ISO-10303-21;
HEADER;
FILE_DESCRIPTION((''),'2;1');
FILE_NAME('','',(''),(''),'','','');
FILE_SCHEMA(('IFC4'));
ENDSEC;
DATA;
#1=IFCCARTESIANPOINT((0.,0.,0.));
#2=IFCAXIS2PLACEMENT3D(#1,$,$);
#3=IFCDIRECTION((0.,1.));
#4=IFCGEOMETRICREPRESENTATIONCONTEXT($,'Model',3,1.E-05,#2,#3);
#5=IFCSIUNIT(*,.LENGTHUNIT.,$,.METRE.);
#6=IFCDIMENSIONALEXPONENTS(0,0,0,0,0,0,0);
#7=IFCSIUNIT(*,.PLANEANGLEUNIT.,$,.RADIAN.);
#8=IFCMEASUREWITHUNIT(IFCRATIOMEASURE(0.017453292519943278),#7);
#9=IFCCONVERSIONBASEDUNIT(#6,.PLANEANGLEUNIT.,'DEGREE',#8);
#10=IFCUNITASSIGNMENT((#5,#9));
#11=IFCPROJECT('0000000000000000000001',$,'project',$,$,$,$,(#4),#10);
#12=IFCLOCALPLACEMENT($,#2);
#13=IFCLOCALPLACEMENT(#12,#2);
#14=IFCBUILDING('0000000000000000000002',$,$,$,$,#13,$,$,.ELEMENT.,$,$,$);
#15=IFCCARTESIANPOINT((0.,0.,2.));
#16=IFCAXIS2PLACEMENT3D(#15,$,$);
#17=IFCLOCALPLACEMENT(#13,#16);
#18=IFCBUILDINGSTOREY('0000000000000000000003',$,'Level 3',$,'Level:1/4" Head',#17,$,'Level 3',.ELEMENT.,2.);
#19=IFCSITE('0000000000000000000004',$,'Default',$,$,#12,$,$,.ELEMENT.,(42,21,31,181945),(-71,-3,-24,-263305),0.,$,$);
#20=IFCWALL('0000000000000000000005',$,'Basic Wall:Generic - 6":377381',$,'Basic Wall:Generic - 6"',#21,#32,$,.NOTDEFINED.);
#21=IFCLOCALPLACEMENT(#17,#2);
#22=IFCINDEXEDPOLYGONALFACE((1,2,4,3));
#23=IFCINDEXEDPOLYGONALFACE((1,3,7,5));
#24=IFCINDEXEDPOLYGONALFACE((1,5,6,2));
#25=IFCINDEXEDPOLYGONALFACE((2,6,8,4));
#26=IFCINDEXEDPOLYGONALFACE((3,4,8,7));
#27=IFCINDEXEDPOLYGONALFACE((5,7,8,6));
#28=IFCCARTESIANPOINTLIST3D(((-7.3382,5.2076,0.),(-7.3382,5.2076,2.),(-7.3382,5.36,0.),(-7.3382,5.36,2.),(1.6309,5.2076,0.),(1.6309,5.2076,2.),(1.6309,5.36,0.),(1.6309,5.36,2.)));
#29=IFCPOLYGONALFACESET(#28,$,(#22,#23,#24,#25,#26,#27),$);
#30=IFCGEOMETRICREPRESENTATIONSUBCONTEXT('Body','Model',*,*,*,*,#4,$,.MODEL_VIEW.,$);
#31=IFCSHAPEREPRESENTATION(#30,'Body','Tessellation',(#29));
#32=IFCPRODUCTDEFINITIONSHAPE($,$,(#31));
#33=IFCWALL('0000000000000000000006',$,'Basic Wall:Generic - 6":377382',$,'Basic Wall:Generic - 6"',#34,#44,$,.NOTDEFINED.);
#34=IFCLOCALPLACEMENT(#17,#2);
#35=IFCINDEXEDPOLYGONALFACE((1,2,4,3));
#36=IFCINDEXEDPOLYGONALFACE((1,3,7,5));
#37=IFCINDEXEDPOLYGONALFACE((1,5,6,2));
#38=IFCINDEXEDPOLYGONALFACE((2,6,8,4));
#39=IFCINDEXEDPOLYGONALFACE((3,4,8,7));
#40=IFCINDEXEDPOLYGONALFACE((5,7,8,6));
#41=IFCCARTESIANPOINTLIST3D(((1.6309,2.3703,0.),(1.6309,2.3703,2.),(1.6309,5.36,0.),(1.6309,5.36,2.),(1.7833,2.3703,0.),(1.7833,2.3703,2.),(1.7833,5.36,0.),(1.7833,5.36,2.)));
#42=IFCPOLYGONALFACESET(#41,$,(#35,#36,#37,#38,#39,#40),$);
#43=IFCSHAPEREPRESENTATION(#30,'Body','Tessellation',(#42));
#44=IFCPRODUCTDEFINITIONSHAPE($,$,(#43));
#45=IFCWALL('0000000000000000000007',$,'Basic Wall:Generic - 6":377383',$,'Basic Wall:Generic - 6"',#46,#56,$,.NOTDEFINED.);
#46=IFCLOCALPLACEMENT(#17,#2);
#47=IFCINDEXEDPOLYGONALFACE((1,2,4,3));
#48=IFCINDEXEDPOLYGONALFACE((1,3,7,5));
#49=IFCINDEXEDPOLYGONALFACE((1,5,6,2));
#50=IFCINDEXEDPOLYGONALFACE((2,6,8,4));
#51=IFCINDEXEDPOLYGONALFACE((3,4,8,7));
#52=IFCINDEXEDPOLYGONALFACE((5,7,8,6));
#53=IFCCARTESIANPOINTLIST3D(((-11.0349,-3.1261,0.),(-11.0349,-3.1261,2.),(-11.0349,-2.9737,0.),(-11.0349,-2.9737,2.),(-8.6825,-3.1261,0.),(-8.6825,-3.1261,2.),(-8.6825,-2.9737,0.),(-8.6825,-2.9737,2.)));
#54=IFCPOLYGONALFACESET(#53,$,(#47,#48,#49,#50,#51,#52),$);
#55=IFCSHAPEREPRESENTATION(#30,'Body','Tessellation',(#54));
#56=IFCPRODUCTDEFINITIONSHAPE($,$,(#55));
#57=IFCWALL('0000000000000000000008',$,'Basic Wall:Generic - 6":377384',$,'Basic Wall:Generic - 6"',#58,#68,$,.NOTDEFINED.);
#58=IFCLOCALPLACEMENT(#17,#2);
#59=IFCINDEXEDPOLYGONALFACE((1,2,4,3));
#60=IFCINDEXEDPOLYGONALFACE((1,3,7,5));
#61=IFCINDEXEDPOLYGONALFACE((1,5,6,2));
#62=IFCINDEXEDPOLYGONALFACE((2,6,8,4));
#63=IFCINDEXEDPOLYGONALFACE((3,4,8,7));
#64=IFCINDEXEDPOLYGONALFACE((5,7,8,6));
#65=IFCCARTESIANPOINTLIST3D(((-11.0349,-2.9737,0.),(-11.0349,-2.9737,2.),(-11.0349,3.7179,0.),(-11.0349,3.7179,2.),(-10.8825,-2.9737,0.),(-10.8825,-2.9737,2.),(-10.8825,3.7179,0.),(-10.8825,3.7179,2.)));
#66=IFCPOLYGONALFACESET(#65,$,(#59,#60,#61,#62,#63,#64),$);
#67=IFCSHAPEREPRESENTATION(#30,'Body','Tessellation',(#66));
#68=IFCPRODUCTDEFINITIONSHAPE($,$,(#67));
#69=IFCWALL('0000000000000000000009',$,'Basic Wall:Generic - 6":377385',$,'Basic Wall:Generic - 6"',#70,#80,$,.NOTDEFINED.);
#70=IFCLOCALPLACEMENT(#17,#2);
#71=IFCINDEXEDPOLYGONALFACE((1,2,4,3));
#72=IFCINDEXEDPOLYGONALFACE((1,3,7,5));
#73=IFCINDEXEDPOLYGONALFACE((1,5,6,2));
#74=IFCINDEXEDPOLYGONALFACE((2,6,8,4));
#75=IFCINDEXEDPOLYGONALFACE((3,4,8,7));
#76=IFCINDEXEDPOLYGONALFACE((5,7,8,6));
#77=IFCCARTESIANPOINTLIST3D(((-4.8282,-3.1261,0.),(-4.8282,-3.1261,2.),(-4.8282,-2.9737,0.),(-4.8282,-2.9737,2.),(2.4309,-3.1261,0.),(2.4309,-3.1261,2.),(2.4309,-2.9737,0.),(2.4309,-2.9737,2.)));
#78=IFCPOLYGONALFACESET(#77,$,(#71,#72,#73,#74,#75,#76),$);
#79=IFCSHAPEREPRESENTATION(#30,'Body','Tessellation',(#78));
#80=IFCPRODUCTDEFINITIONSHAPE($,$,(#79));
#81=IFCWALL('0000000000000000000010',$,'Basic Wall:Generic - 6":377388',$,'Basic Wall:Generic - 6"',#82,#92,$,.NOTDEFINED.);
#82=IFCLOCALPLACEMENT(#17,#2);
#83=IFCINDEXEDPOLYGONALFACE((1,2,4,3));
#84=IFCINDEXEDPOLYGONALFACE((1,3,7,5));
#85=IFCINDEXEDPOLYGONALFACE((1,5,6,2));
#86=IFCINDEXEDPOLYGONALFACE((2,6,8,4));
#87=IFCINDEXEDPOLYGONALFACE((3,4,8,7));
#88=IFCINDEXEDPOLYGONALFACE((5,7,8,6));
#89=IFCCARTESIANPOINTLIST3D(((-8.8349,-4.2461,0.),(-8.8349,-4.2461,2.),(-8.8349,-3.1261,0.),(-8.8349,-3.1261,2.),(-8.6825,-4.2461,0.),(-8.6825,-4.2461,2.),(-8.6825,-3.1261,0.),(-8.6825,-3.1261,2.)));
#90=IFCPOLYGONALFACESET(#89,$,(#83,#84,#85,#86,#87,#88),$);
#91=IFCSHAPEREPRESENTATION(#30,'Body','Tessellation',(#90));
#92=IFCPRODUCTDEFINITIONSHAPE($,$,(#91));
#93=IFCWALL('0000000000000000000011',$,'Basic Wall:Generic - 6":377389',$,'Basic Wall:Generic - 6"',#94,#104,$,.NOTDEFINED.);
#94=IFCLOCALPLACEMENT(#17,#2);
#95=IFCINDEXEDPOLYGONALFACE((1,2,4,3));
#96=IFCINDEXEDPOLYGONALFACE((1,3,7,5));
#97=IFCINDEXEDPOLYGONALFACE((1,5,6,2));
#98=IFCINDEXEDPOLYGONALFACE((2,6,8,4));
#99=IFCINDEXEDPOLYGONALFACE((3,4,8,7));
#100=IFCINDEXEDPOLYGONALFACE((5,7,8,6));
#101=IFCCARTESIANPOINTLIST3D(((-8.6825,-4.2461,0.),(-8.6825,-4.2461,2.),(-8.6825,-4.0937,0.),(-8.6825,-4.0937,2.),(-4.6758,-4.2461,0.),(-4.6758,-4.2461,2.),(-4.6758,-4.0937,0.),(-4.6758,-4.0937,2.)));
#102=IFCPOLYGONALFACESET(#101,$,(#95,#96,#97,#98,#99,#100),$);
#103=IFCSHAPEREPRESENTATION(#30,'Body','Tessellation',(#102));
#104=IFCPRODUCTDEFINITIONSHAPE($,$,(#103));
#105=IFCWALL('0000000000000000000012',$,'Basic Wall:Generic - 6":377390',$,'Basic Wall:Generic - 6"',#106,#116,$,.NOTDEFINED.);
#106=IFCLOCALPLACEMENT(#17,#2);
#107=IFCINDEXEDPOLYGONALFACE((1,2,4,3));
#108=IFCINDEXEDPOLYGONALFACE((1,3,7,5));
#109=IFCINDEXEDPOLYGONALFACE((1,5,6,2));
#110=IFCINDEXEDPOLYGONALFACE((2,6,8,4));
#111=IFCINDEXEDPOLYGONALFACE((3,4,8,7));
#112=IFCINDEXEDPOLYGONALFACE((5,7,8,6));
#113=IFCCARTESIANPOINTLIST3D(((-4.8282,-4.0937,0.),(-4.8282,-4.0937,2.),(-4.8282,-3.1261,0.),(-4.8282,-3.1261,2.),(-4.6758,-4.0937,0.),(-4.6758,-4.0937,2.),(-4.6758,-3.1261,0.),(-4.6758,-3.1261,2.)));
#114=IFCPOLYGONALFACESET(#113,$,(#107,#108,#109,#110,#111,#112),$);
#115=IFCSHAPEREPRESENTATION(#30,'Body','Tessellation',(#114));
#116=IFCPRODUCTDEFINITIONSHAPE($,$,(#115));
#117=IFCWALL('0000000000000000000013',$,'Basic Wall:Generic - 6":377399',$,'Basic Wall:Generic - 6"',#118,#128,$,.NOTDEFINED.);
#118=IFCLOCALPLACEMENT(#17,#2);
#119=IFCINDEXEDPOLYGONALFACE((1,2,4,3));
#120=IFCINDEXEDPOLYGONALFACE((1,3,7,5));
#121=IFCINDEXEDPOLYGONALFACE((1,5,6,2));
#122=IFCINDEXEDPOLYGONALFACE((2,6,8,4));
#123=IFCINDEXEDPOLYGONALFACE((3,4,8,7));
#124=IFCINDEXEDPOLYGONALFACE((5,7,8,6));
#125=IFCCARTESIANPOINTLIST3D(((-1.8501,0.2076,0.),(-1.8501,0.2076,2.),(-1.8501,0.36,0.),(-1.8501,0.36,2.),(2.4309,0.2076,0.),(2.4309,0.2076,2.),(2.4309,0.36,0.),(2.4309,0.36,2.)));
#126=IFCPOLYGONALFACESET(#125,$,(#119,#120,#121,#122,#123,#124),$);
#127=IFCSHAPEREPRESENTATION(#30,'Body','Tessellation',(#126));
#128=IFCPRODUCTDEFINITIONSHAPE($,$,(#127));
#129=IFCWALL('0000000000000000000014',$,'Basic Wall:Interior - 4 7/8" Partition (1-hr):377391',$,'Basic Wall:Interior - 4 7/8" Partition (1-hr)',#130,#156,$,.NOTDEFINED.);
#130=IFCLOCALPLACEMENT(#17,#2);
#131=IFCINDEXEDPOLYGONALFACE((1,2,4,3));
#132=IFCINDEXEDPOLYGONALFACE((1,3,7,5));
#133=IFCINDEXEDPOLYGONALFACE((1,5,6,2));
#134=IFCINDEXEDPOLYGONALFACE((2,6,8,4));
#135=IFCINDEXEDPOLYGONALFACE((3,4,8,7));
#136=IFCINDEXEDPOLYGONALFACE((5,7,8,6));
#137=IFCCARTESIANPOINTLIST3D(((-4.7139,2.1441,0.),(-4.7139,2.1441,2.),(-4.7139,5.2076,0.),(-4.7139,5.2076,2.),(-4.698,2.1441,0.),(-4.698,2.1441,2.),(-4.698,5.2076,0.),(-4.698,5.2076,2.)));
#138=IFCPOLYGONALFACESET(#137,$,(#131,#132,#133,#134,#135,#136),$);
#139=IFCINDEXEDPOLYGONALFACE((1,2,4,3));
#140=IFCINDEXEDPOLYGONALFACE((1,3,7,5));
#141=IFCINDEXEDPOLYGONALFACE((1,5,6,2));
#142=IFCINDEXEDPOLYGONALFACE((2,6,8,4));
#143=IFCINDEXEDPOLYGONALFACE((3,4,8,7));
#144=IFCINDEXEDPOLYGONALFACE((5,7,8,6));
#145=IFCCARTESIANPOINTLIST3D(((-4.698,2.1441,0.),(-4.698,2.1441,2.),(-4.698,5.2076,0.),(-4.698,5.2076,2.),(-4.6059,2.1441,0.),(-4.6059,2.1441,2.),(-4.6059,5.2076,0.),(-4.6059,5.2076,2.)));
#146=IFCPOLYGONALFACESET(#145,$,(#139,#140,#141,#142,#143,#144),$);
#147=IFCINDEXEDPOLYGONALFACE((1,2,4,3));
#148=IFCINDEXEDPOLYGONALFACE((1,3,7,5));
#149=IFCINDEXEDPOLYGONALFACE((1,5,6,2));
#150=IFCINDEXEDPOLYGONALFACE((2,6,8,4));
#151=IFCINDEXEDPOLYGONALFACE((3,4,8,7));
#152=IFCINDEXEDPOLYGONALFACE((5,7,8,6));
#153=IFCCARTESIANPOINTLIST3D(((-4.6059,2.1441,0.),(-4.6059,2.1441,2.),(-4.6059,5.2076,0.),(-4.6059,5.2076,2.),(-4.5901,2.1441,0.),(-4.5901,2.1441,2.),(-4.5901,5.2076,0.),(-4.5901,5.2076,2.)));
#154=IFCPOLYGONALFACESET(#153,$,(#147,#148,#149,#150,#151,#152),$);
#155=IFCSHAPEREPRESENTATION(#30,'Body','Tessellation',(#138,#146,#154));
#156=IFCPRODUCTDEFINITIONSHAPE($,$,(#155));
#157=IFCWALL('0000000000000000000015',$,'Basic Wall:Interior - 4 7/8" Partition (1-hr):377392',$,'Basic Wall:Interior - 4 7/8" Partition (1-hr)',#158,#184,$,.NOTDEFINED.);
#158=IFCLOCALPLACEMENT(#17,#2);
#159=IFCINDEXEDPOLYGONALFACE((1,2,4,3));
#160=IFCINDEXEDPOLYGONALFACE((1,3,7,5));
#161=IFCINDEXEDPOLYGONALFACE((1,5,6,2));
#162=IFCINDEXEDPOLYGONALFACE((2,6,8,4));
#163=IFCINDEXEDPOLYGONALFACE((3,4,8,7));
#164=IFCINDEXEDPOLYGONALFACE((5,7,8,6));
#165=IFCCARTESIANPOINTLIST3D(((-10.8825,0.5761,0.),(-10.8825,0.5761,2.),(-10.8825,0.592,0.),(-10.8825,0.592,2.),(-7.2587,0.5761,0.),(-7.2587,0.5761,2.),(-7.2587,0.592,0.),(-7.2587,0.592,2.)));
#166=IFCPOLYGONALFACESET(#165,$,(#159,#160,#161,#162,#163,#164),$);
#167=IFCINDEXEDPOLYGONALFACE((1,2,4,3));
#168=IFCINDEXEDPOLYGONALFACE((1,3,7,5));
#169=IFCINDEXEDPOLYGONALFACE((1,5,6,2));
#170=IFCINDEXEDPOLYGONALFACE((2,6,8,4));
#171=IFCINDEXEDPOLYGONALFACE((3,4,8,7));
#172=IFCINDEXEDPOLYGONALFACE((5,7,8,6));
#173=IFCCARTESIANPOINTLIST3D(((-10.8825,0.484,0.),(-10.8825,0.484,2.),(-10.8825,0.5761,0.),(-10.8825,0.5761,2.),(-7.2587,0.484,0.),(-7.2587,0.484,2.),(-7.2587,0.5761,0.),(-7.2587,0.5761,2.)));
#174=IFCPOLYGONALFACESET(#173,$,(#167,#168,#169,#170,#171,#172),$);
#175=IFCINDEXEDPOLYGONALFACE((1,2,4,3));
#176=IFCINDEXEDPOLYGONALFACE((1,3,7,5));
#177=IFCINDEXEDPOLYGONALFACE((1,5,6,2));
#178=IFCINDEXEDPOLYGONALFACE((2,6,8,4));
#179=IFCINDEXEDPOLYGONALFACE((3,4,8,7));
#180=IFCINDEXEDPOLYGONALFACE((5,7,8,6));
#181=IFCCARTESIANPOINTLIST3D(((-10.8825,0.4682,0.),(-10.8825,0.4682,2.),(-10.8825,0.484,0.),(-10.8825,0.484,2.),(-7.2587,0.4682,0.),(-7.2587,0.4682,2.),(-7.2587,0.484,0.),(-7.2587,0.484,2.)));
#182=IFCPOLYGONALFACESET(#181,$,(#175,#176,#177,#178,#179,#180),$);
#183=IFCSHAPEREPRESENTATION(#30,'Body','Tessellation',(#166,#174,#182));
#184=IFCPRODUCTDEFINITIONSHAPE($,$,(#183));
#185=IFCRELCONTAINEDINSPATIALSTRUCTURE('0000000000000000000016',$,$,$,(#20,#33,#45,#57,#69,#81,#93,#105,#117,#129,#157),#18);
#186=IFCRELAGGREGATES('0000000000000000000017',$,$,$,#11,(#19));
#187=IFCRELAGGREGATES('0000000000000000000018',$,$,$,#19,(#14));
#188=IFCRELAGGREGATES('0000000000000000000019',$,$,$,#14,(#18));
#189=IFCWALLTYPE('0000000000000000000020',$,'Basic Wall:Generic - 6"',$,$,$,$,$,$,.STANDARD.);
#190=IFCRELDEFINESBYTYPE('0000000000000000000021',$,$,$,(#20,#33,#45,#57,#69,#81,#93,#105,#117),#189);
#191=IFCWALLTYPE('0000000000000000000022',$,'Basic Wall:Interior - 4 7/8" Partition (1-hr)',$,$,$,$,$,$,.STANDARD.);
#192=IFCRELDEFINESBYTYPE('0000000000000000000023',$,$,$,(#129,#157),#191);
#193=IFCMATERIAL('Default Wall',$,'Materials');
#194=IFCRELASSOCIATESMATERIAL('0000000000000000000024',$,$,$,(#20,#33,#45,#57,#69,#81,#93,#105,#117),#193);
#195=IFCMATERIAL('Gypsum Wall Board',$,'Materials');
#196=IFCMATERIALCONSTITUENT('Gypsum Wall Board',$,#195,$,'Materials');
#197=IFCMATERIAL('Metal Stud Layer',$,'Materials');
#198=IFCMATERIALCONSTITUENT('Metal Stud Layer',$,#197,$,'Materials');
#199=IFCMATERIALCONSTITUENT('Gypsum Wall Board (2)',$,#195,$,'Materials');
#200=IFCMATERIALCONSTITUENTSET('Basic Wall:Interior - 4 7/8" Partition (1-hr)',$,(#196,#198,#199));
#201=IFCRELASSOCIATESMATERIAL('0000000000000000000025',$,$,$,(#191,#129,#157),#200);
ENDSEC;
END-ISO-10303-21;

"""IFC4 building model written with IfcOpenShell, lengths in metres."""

from ifc_helpers import new_model, entity, si_unit, converted_unit, direction, frame, origin, place, context, subcontext, project, spatial, indexed_curve, outline, extrude, material, constituent, constituent_set, type_object, element, save


model = new_model("IFC4")

# Units and contexts
model_context = context("Model", 3, precision=1e-05, world=origin(), true_north=direction((0.0, 1.0)))
body_context = subcontext(model_context, "Body", "Model", "MODEL_VIEW")
ifc_project = project(units=[si_unit("LENGTHUNIT", "METRE"), converted_unit("PLANEANGLEUNIT", "DEGREE", entity("IfcRatioMeasure", 0.017453292519943278), si_unit("PLANEANGLEUNIT", "RADIAN"), dimensions=[0, 0, 0, 0, 0, 0, 0])], contexts=[model_context])

# Site, building, storey
site_placement = place(None, origin())
site = spatial("IfcSite", under=ifc_project, at=site_placement, Name="Default", CompositionType="ELEMENT", RefLatitude=(42, 21, 31, 181945), RefLongitude=(-71, -3, -24, -263305), RefElevation=0.0)
building_placement = place(site_placement, origin())
building = spatial("IfcBuilding", under=site, at=building_placement, CompositionType="ELEMENT")
storey_placement = place(building_placement, frame((0.0, 0.0, 2.0)))
storey = spatial("IfcBuildingStorey", under=building, at=storey_placement, Name="Level 3", ObjectType="Level:1/4\" Head", LongName="Level 3", CompositionType="ELEMENT", Elevation=2.0)

# Walls
ifc_material_1 = material(Name="Default Wall", Category="Materials")
wall_type_1 = type_object("IfcWallType", Name="Basic Wall:Generic - 6\"", PredefinedType="STANDARD")
wall_1_placement = place(storey_placement, frame((1.6309, 5.2838, 0.0), z_axis=(0.0, 0.0, 1.0), x_axis=(-1.0, 0.0, 0.0)))
element("IfcWall", 1, at=wall_1_placement, inside=storey, type_object=wall_type_1, material=ifc_material_1, Name="Basic Wall:Generic - 6\":377381", ObjectType="Basic Wall:Generic - 6\"", PredefinedType="NOTDEFINED", context=body_context, shape_type="SweptSolid", body=[
    extrude(outline(indexed_curve([(8.9691, 0.0762), (0.0, 0.0762), (0.0, -0.0762), (8.9691, -0.0762), (8.9691, 0.0762)], self_intersect=False)), origin(), (0.0, 0.0, 1.0), 2.0),
])
wall_2_placement = place(storey_placement, frame((1.7071, 5.36, 0.0), z_axis=(0.0, 0.0, 1.0), x_axis=(0.0, -1.0, 0.0)))
element("IfcWall", 2, at=wall_2_placement, inside=storey, type_object=wall_type_1, material=ifc_material_1, Name="Basic Wall:Generic - 6\":377382", ObjectType="Basic Wall:Generic - 6\"", PredefinedType="NOTDEFINED", context=body_context, shape_type="SweptSolid", body=[
    extrude(outline(indexed_curve([(2.9897, 0.0762), (0.0, 0.0762), (0.0, -0.0762), (2.9897, -0.0762), (2.9897, 0.0762)], self_intersect=False)), origin(), (0.0, 0.0, 1.0), 2.0),
])
wall_3_placement = place(storey_placement, frame((-8.6825, -3.0499, 0.0), z_axis=(0.0, 0.0, 1.0), x_axis=(-1.0, 0.0, 0.0)))
element("IfcWall", 3, at=wall_3_placement, inside=storey, type_object=wall_type_1, material=ifc_material_1, Name="Basic Wall:Generic - 6\":377383", ObjectType="Basic Wall:Generic - 6\"", PredefinedType="NOTDEFINED", context=body_context, shape_type="SweptSolid", body=[
    extrude(outline(indexed_curve([(2.3524, 0.0762), (0.0, 0.0762), (0.0, -0.0762), (2.3524, -0.0762), (2.3524, 0.0762)], self_intersect=False)), origin(), (0.0, 0.0, 1.0), 2.0),
])
wall_4_placement = place(storey_placement, frame((-10.9587, 3.7179, 0.0), z_axis=(0.0, 0.0, 1.0), x_axis=(0.0, -1.0, 0.0)))
element("IfcWall", 4, at=wall_4_placement, inside=storey, type_object=wall_type_1, material=ifc_material_1, Name="Basic Wall:Generic - 6\":377384", ObjectType="Basic Wall:Generic - 6\"", PredefinedType="NOTDEFINED", context=body_context, shape_type="SweptSolid", body=[
    extrude(outline(indexed_curve([(6.6916, 0.0762), (0.0, 0.0762), (0.0, -0.0762), (6.6916, -0.0762), (6.6916, 0.0762)], self_intersect=False)), origin(), (0.0, 0.0, 1.0), 2.0),
])
wall_5_placement = place(storey_placement, frame((2.4309, -3.0499, 0.0), z_axis=(0.0, 0.0, 1.0), x_axis=(-1.0, 0.0, 0.0)))
element("IfcWall", 5, at=wall_5_placement, inside=storey, type_object=wall_type_1, material=ifc_material_1, Name="Basic Wall:Generic - 6\":377385", ObjectType="Basic Wall:Generic - 6\"", PredefinedType="NOTDEFINED", context=body_context, shape_type="SweptSolid", body=[
    extrude(outline(indexed_curve([(7.2591, 0.0762), (0.0, 0.0762), (0.0, -0.0762), (7.2591, -0.0762), (7.2591, 0.0762)], self_intersect=False)), origin(), (0.0, 0.0, 1.0), 2.0),
])
wall_6_placement = place(storey_placement, frame((-8.7587, -3.1261, 0.0), z_axis=(0.0, 0.0, 1.0), x_axis=(0.0, -1.0, 0.0)))
element("IfcWall", 6, at=wall_6_placement, inside=storey, type_object=wall_type_1, material=ifc_material_1, Name="Basic Wall:Generic - 6\":377388", ObjectType="Basic Wall:Generic - 6\"", PredefinedType="NOTDEFINED", context=body_context, shape_type="SweptSolid", body=[
    extrude(outline(indexed_curve([(1.12, 0.0762), (0.0, 0.0762), (0.0, -0.0762), (1.12, -0.0762), (1.12, 0.0762)], self_intersect=False)), origin(), (0.0, 0.0, 1.0), 2.0),
])
wall_7_placement = place(storey_placement, frame((-4.6758, -4.1699, 0.0), z_axis=(0.0, 0.0, 1.0), x_axis=(-1.0, 0.0, 0.0)))
element("IfcWall", 7, at=wall_7_placement, inside=storey, type_object=wall_type_1, material=ifc_material_1, Name="Basic Wall:Generic - 6\":377389", ObjectType="Basic Wall:Generic - 6\"", PredefinedType="NOTDEFINED", context=body_context, shape_type="SweptSolid", body=[
    extrude(outline(indexed_curve([(4.0068, 0.0762), (0.0, 0.0762), (0.0, -0.0762), (4.0068, -0.0762), (4.0068, 0.0762)], self_intersect=False)), origin(), (0.0, 0.0, 1.0), 2.0),
])
wall_8_placement = place(storey_placement, frame((-4.752, -4.0937, 0.0), z_axis=(0.0, 0.0, 1.0), x_axis=(0.0, 1.0, 0.0)))
element("IfcWall", 8, at=wall_8_placement, inside=storey, type_object=wall_type_1, material=ifc_material_1, Name="Basic Wall:Generic - 6\":377390", ObjectType="Basic Wall:Generic - 6\"", PredefinedType="NOTDEFINED", context=body_context, shape_type="SweptSolid", body=[
    extrude(outline(indexed_curve([(0.9676, 0.0762), (0.0, 0.0762), (0.0, -0.0762), (0.9676, -0.0762), (0.9676, 0.0762)], self_intersect=False)), origin(), (0.0, 0.0, 1.0), 2.0),
])
wall_9_placement = place(storey_placement, frame((-1.8501, 0.2838, 0.0)))
element("IfcWall", 9, at=wall_9_placement, inside=storey, type_object=wall_type_1, material=ifc_material_1, Name="Basic Wall:Generic - 6\":377399", ObjectType="Basic Wall:Generic - 6\"", PredefinedType="NOTDEFINED", context=body_context, shape_type="SweptSolid", body=[
    extrude(outline(indexed_curve([(4.281, 0.0762), (0.0, 0.0762), (0.0, -0.0762), (4.281, -0.0762), (4.281, 0.0762)], self_intersect=False)), origin(), (0.0, 0.0, 1.0), 2.0),
])
ifc_material_2 = material(Name="Gypsum Wall Board", Category="Materials")
ifc_constituent_1 = constituent(ifc_material_2, Name="Gypsum Wall Board", Category="Materials")
ifc_material_3 = material(Name="Metal Stud Layer", Category="Materials")
ifc_constituent_2 = constituent(ifc_material_3, Name="Metal Stud Layer", Category="Materials")
ifc_constituent_3 = constituent(ifc_material_2, Name="Gypsum Wall Board (2)", Category="Materials")
ifc_constituent_set = constituent_set(constituents=[ifc_constituent_1, ifc_constituent_2, ifc_constituent_3], Name="Basic Wall:Interior - 4 7/8\" Partition (1-hr)")
wall_type_2 = type_object("IfcWallType", Name="Basic Wall:Interior - 4 7/8\" Partition (1-hr)", PredefinedType="STANDARD", material=ifc_constituent_set)
wall_10_placement = place(storey_placement, frame((-4.652, 5.2076, 0.0), z_axis=(0.0, 0.0, 1.0), x_axis=(0.0, -1.0, 0.0)))
element("IfcWall", 10, at=wall_10_placement, inside=storey, type_object=wall_type_2, material=ifc_constituent_set, Name="Basic Wall:Interior - 4 7/8\" Partition (1-hr):377391", ObjectType="Basic Wall:Interior - 4 7/8\" Partition (1-hr)", PredefinedType="NOTDEFINED", context=body_context, shape_type="SweptSolid", body=[
    extrude(outline(indexed_curve([(-0.0079, -1.5318), (0.0079, -1.5318), (0.0079, 1.5318), (-0.0079, 1.5318), (-0.0079, -1.5318)], self_intersect=False)), frame((1.5318, -0.054, 0.0), z_axis=(0.0, 0.0, 1.0), x_axis=(0.0, 1.0, 0.0)), (0.0, 0.0, 1.0), 2.0),
    extrude(outline(indexed_curve([(-1.5318, -0.046), (1.5318, -0.046), (1.5318, 0.046), (-1.5318, 0.046), (-1.5318, -0.046)], self_intersect=False)), frame((1.5318, 0.0, 0.0)), (0.0, 0.0, 1.0), 2.0),
    extrude(outline(indexed_curve([(-0.0079, -1.5318), (0.0079, -1.5318), (0.0079, 1.5318), (-0.0079, 1.5318), (-0.0079, -1.5318)], self_intersect=False)), frame((1.5318, 0.054, 0.0), z_axis=(0.0, 0.0, 1.0), x_axis=(0.0, -1.0, 0.0)), (0.0, 0.0, 1.0), 2.0),
])
wall_11_placement = place(storey_placement, frame((-10.8825, 0.5301, 0.0)))
element("IfcWall", 11, at=wall_11_placement, inside=storey, type_object=wall_type_2, material=ifc_constituent_set, Name="Basic Wall:Interior - 4 7/8\" Partition (1-hr):377392", ObjectType="Basic Wall:Interior - 4 7/8\" Partition (1-hr)", PredefinedType="NOTDEFINED", context=body_context, shape_type="SweptSolid", body=[
    extrude(outline(indexed_curve([(-0.0079, -1.8119), (0.0079, -1.8119), (0.0079, 1.8119), (-0.0079, 1.8119), (-0.0079, -1.8119)], self_intersect=False)), frame((1.8119, 0.054, 0.0), z_axis=(0.0, 0.0, 1.0), x_axis=(0.0, -1.0, 0.0)), (0.0, 0.0, 1.0), 2.0),
    extrude(outline(indexed_curve([(-1.8119, -0.046), (1.8119, -0.046), (1.8119, 0.046), (-1.8119, 0.046), (-1.8119, -0.046)], self_intersect=False)), frame((1.8119, 0.0, 0.0)), (0.0, 0.0, 1.0), 2.0),
    extrude(outline(indexed_curve([(-0.0079, -1.8119), (0.0079, -1.8119), (0.0079, 1.8119), (-0.0079, 1.8119), (-0.0079, -1.8119)], self_intersect=False)), frame((1.8119, -0.054, 0.0), z_axis=(0.0, 0.0, 1.0), x_axis=(0.0, 1.0, 0.0)), (0.0, 0.0, 1.0), 2.0),
])

save(model, "model.ifc")
